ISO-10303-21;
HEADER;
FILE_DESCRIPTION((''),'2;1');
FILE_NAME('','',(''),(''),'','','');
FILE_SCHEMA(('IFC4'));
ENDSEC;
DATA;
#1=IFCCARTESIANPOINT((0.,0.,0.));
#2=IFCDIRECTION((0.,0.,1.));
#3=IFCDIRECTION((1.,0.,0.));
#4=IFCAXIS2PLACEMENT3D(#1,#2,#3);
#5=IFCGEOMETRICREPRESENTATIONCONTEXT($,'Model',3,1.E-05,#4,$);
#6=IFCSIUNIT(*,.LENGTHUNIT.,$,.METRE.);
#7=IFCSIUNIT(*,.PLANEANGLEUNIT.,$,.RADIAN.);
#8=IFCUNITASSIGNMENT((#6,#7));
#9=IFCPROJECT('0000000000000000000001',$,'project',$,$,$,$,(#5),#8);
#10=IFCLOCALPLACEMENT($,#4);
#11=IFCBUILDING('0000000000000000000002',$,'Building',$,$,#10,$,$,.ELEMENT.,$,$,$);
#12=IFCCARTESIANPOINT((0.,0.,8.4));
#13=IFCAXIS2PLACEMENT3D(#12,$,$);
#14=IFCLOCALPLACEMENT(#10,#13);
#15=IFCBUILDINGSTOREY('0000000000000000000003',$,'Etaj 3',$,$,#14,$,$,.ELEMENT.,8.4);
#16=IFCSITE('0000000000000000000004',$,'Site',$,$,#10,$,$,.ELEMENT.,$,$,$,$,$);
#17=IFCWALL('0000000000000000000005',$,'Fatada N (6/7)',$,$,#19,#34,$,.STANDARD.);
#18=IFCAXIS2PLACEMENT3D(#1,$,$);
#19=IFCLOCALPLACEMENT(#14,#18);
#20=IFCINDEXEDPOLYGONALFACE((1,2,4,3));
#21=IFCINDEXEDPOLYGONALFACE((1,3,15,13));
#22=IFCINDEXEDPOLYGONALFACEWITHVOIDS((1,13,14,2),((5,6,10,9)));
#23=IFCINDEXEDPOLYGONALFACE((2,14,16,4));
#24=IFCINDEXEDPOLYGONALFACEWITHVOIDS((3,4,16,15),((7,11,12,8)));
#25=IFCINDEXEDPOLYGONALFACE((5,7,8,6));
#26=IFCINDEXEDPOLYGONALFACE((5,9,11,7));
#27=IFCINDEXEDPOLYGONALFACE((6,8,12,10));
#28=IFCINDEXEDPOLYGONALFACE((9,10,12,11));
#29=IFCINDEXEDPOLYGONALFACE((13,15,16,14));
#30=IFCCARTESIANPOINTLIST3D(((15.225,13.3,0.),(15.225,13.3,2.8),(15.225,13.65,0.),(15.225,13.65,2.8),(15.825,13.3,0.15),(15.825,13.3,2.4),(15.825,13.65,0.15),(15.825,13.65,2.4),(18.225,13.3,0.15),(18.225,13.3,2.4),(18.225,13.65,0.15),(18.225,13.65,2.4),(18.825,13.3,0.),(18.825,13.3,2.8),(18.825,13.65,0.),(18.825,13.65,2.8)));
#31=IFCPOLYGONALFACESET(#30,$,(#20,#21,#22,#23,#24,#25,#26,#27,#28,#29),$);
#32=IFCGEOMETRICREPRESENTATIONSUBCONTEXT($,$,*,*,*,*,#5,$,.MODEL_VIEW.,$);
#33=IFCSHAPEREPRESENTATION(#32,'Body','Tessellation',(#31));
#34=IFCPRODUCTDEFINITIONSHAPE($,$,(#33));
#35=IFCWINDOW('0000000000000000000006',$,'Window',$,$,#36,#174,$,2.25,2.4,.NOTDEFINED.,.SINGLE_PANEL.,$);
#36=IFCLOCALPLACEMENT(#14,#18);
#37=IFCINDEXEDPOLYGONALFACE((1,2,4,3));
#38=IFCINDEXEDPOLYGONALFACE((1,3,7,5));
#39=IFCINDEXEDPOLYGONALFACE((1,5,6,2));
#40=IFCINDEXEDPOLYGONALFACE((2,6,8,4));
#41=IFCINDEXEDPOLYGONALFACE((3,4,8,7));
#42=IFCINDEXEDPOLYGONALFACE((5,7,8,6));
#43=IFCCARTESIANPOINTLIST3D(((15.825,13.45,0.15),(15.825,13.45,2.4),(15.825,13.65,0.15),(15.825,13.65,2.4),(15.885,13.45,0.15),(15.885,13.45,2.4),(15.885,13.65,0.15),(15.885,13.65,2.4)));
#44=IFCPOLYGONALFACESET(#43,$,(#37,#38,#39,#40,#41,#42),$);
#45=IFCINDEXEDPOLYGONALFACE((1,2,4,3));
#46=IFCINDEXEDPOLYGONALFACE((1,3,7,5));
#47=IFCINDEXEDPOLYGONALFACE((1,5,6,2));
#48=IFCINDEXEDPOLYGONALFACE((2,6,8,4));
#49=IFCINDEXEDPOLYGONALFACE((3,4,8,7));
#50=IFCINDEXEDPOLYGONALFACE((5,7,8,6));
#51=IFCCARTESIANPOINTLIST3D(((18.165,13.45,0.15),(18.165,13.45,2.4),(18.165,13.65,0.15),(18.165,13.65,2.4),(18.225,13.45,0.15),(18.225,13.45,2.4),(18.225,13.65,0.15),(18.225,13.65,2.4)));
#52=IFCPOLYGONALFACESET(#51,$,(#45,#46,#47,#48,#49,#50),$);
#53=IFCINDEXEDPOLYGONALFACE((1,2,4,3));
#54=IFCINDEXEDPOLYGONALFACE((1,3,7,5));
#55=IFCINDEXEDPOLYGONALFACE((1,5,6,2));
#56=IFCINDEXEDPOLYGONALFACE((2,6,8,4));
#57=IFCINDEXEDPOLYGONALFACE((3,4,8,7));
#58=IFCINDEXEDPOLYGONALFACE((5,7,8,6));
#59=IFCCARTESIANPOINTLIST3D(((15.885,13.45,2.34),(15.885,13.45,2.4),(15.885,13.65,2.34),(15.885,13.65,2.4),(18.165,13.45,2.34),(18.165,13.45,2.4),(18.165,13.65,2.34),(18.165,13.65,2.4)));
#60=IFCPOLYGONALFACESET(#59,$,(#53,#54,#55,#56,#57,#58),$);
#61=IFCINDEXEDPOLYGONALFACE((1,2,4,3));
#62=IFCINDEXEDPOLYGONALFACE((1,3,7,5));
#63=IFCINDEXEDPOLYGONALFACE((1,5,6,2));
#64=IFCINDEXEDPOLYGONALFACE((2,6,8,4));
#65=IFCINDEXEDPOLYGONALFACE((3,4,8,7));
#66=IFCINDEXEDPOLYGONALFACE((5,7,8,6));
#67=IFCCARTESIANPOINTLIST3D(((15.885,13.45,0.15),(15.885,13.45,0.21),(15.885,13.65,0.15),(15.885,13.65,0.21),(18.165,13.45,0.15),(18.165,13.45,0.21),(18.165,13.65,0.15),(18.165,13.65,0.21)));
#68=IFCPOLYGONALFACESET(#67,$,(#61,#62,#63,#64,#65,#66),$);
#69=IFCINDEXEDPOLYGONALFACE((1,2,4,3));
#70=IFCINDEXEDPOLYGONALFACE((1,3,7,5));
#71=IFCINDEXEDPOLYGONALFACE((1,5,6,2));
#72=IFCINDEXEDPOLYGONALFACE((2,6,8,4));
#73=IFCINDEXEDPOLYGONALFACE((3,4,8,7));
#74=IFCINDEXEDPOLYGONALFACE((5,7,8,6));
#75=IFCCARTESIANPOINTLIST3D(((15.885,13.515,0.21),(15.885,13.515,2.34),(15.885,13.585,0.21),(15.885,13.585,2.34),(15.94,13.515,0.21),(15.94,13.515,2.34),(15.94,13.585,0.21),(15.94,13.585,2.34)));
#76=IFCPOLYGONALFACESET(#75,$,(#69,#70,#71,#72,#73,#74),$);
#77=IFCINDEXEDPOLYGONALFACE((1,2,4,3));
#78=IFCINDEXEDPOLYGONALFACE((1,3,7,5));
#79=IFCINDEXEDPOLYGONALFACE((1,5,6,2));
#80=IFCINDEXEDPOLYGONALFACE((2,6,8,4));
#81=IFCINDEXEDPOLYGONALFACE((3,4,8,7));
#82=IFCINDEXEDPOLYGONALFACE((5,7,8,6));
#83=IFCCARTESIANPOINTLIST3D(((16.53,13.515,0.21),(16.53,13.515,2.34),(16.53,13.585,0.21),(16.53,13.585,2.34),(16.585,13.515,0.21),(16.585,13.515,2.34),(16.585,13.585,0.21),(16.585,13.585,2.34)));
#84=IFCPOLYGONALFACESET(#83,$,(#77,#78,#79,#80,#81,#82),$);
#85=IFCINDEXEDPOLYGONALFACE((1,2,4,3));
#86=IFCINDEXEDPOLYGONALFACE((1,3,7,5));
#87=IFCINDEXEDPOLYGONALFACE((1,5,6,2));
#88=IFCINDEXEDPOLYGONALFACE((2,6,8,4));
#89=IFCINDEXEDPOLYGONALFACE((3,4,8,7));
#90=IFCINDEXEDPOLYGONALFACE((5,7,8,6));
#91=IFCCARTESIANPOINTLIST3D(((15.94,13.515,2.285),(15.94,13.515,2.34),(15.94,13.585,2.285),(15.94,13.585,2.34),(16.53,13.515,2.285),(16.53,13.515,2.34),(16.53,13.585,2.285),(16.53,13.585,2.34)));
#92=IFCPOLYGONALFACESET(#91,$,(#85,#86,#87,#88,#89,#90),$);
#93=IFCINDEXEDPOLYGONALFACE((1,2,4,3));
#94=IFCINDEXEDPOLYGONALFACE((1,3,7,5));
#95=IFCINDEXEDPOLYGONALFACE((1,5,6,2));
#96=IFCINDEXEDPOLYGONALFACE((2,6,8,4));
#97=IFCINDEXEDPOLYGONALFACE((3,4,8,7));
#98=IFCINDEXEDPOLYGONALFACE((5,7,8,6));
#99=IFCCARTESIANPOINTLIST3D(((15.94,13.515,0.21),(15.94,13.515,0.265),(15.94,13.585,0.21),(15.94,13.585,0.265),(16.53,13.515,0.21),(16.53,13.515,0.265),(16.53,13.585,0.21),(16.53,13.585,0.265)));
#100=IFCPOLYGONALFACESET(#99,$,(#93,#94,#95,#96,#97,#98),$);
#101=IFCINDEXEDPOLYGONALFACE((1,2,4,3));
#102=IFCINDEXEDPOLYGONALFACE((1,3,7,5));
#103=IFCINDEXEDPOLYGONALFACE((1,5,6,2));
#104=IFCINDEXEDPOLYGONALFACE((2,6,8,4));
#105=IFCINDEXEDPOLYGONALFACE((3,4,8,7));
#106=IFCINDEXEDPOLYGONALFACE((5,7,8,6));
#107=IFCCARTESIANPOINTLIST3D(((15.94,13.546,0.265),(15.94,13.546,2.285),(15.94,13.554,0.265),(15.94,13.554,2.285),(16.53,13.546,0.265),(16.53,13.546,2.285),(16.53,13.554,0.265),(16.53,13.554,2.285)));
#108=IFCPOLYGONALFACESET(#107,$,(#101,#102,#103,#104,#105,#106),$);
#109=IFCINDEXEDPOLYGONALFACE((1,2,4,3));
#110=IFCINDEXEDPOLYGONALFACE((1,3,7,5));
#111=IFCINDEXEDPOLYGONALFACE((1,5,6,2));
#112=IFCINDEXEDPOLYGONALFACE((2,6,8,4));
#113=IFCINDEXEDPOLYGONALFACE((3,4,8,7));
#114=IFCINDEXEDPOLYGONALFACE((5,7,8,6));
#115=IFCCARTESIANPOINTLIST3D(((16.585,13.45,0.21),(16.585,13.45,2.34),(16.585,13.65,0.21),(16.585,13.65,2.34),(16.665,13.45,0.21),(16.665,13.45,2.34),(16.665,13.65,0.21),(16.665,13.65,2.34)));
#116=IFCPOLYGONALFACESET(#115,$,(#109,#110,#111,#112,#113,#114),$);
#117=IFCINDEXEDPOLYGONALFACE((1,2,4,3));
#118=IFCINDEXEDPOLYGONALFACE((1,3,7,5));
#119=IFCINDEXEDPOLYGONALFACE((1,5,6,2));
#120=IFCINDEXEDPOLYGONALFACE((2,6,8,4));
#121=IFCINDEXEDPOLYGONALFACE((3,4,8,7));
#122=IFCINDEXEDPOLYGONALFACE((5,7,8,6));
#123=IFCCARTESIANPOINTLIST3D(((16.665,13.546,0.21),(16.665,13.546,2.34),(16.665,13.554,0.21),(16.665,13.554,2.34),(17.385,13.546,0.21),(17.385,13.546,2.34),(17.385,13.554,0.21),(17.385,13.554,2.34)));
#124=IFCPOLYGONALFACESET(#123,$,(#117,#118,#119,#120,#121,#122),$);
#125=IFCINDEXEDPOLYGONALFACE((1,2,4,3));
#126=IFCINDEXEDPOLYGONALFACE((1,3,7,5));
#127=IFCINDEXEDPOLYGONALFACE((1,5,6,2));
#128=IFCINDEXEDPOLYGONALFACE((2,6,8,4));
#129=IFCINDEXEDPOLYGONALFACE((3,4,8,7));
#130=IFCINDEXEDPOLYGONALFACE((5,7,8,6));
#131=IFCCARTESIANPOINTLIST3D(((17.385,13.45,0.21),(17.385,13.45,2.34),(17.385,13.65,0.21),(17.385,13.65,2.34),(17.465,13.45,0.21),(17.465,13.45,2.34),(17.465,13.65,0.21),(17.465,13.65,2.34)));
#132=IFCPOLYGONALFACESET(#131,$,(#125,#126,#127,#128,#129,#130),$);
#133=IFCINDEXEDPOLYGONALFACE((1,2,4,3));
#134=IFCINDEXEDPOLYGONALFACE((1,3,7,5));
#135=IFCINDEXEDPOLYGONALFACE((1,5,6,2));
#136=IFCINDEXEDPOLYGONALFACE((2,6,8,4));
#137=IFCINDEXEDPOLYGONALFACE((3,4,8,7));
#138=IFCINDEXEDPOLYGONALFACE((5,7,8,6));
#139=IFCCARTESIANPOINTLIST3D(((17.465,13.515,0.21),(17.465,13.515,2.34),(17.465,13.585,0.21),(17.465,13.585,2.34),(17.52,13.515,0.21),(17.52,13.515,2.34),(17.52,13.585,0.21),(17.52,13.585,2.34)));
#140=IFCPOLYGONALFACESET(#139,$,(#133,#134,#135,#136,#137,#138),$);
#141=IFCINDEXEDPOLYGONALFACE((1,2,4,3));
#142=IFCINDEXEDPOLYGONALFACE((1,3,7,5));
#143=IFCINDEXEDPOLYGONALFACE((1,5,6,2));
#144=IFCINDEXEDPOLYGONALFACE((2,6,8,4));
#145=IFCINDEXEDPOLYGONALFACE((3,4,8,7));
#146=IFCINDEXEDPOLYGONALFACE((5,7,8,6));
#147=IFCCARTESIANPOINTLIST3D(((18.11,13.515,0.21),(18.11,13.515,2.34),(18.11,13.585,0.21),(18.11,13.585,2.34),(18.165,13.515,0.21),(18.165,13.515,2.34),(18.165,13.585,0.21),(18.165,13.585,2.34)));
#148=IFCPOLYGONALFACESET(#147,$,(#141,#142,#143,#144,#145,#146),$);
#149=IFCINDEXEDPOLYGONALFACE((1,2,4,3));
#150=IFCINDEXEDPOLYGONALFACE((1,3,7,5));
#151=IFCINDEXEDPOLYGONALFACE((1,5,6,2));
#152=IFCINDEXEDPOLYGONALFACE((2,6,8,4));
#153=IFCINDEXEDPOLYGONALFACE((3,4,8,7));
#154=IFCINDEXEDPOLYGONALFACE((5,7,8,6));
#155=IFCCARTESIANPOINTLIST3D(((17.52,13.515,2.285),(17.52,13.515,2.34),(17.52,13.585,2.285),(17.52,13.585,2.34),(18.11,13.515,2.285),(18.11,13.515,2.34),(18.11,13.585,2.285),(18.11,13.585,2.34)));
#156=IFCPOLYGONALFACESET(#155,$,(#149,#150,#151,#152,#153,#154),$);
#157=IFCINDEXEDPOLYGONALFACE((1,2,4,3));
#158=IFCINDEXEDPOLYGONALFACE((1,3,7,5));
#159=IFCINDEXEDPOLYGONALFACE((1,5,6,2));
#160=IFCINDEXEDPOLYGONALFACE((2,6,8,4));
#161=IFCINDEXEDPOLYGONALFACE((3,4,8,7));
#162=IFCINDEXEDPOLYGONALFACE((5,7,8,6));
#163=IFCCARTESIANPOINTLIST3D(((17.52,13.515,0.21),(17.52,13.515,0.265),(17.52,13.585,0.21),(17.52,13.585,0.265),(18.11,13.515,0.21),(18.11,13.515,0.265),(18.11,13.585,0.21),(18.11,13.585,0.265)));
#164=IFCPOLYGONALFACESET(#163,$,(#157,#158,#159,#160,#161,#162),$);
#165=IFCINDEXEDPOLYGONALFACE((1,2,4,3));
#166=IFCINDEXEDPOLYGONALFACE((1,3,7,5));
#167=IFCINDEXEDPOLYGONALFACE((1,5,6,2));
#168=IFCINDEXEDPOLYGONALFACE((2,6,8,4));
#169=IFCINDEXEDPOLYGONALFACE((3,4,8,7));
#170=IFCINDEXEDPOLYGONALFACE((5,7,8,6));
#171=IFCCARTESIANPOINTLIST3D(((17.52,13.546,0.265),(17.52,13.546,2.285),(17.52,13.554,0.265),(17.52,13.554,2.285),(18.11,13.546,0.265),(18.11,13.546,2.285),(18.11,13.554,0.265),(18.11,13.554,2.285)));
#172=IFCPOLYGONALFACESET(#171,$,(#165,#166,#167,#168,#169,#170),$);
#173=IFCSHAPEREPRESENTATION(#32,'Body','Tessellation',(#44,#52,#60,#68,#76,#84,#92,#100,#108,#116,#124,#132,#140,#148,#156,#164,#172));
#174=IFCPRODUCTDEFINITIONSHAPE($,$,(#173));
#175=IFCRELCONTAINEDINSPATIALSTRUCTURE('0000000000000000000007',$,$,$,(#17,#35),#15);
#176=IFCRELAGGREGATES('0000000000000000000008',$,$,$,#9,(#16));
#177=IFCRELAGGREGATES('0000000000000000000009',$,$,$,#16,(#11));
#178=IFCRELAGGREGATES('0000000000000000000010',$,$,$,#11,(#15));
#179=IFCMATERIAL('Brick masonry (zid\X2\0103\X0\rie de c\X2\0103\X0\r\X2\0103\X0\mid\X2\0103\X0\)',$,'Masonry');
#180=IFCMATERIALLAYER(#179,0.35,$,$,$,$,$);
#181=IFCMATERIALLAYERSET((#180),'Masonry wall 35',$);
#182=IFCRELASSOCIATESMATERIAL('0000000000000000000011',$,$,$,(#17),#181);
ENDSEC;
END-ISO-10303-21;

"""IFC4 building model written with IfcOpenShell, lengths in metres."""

from ifc_helpers import new_model, si_unit, frame, frame_2d, origin, origin_with_axes, origin_2d, place, context, subcontext, project, spatial, rectangle, extrude, material, layer, layer_set, layer_usage, element, fill, save


model = new_model("IFC4")

# Units and contexts
model_context = context("Model", 3, precision=1e-05, world=origin_with_axes())
sub_context = subcontext(model_context, None, None, "MODEL_VIEW")
ifc_project = project(units=[si_unit("LENGTHUNIT", "METRE"), si_unit("PLANEANGLEUNIT", "RADIAN")], contexts=[model_context])

# Site, building, storey
placement = place(None, origin_with_axes())
site = spatial("IfcSite", under=ifc_project, at=placement, Name="Site", CompositionType="ELEMENT")
building = spatial("IfcBuilding", under=site, at=placement, Name="Building", CompositionType="ELEMENT")
storey_placement = place(placement, frame((0.0, 0.0, 8.4)))
storey = spatial("IfcBuildingStorey", under=building, at=storey_placement, Name="Etaj 3", CompositionType="ELEMENT", Elevation=8.4)

# Wall, opening, window
ifc_material_1 = material(Name="Brick masonry (zidărie de cărămidă)", Category="Masonry")
ifc_layer_1 = layer(ifc_material_1, 0.35)
ifc_layer_set_1 = layer_set([ifc_layer_1], Name="Masonry wall 35")
ifc_layer_usage_1 = layer_usage(ifc_layer_set_1, "AXIS2", "POSITIVE", -0.175)
wall_1_placement = place(storey_placement, frame((15.225, 13.475, 0.0), x_axis=(1.0, 0.0, 0.0)))
wall_1 = element("IfcWall", 1, at=wall_1_placement, inside=storey, material=ifc_layer_usage_1, Name="Fatada N (6/7)", PredefinedType="STANDARD", context=sub_context, shape_type="SweptSolid", body=[
    extrude(rectangle(XDim=3.6, YDim=0.35, at=frame_2d((1.8, 0.0))), origin(), (0.0, 0.0, 1.0), 2.8),
])
opening_1_placement = place(wall_1_placement, frame((1.8, 0.225, 0.15), z_axis=(0.0, -1.0, 0.0), x_axis=(1.0, 0.0, 0.0)))
opening_1 = element("IfcOpeningElement", 2, at=opening_1_placement, cuts=wall_1, PredefinedType="OPENING", context=sub_context, shape_type="SweptSolid", body=[
    extrude(rectangle(XDim=2.4, YDim=2.25, at=frame_2d((0.0, 1.125))), origin(), (0.0, 0.0, 1.0), 0.45),
])
window_1_placement = place(wall_1_placement, frame((1.8, 0.175, 0.15), z_axis=(0.0, -1.0, 0.0), x_axis=(1.0, 0.0, 0.0)))
window_1 = element("IfcWindow", 3, at=window_1_placement, inside=storey, Name="Window", OverallHeight=2.25, OverallWidth=2.4, PartitioningType="SINGLE_PANEL", PredefinedType="NOTDEFINED", context=sub_context, shape_type="SweptSolid", body=[
    extrude(rectangle(XDim=0.06, YDim=2.25, at=origin_2d()), frame((-1.17, 1.125, 0.0)), (0.0, 0.0, 1.0), 0.2),
    extrude(rectangle(XDim=0.06, YDim=2.25, at=origin_2d()), frame((1.17, 1.125, 0.0)), (0.0, 0.0, 1.0), 0.2),
    extrude(rectangle(XDim=2.28, YDim=0.06, at=origin_2d()), frame((0.0, 2.22, 0.0)), (0.0, 0.0, 1.0), 0.2),
    extrude(rectangle(XDim=2.28, YDim=0.06, at=origin_2d()), frame((0.0, 0.03, 0.0)), (0.0, 0.0, 1.0), 0.2),
    extrude(rectangle(XDim=0.055, YDim=2.13, at=origin_2d()), frame((-1.1125, 1.125, 0.065)), (0.0, 0.0, 1.0), 0.07),
    extrude(rectangle(XDim=0.055, YDim=2.13, at=origin_2d()), frame((-0.4675, 1.125, 0.065)), (0.0, 0.0, 1.0), 0.07),
    extrude(rectangle(XDim=0.59, YDim=0.055, at=origin_2d()), frame((-0.79, 2.1625, 0.065)), (0.0, 0.0, 1.0), 0.07),
    extrude(rectangle(XDim=0.59, YDim=0.055, at=origin_2d()), frame((-0.79, 0.0875, 0.065)), (0.0, 0.0, 1.0), 0.07),
    extrude(rectangle(XDim=0.59, YDim=2.02, at=origin_2d()), frame((-0.79, 1.125, 0.096)), (0.0, 0.0, 1.0), 0.008),
    extrude(rectangle(XDim=0.08, YDim=2.13, at=origin_2d()), frame((-0.4, 1.125, 0.0)), (0.0, 0.0, 1.0), 0.2),
    extrude(rectangle(XDim=0.72, YDim=2.13, at=origin_2d()), frame((0.0, 1.125, 0.096)), (0.0, 0.0, 1.0), 0.008),
    extrude(rectangle(XDim=0.08, YDim=2.13, at=origin_2d()), frame((0.4, 1.125, 0.0)), (0.0, 0.0, 1.0), 0.2),
    extrude(rectangle(XDim=0.055, YDim=2.13, at=origin_2d()), frame((0.4675, 1.125, 0.065)), (0.0, 0.0, 1.0), 0.07),
    extrude(rectangle(XDim=0.055, YDim=2.13, at=origin_2d()), frame((1.1125, 1.125, 0.065)), (0.0, 0.0, 1.0), 0.07),
    extrude(rectangle(XDim=0.59, YDim=0.055, at=origin_2d()), frame((0.79, 2.1625, 0.065)), (0.0, 0.0, 1.0), 0.07),
    extrude(rectangle(XDim=0.59, YDim=0.055, at=origin_2d()), frame((0.79, 0.0875, 0.065)), (0.0, 0.0, 1.0), 0.07),
    extrude(rectangle(XDim=0.59, YDim=2.02, at=origin_2d()), frame((0.79, 1.125, 0.096)), (0.0, 0.0, 1.0), 0.008),
])
fill(opening_1, window_1)

save(model, "model.ifc")
